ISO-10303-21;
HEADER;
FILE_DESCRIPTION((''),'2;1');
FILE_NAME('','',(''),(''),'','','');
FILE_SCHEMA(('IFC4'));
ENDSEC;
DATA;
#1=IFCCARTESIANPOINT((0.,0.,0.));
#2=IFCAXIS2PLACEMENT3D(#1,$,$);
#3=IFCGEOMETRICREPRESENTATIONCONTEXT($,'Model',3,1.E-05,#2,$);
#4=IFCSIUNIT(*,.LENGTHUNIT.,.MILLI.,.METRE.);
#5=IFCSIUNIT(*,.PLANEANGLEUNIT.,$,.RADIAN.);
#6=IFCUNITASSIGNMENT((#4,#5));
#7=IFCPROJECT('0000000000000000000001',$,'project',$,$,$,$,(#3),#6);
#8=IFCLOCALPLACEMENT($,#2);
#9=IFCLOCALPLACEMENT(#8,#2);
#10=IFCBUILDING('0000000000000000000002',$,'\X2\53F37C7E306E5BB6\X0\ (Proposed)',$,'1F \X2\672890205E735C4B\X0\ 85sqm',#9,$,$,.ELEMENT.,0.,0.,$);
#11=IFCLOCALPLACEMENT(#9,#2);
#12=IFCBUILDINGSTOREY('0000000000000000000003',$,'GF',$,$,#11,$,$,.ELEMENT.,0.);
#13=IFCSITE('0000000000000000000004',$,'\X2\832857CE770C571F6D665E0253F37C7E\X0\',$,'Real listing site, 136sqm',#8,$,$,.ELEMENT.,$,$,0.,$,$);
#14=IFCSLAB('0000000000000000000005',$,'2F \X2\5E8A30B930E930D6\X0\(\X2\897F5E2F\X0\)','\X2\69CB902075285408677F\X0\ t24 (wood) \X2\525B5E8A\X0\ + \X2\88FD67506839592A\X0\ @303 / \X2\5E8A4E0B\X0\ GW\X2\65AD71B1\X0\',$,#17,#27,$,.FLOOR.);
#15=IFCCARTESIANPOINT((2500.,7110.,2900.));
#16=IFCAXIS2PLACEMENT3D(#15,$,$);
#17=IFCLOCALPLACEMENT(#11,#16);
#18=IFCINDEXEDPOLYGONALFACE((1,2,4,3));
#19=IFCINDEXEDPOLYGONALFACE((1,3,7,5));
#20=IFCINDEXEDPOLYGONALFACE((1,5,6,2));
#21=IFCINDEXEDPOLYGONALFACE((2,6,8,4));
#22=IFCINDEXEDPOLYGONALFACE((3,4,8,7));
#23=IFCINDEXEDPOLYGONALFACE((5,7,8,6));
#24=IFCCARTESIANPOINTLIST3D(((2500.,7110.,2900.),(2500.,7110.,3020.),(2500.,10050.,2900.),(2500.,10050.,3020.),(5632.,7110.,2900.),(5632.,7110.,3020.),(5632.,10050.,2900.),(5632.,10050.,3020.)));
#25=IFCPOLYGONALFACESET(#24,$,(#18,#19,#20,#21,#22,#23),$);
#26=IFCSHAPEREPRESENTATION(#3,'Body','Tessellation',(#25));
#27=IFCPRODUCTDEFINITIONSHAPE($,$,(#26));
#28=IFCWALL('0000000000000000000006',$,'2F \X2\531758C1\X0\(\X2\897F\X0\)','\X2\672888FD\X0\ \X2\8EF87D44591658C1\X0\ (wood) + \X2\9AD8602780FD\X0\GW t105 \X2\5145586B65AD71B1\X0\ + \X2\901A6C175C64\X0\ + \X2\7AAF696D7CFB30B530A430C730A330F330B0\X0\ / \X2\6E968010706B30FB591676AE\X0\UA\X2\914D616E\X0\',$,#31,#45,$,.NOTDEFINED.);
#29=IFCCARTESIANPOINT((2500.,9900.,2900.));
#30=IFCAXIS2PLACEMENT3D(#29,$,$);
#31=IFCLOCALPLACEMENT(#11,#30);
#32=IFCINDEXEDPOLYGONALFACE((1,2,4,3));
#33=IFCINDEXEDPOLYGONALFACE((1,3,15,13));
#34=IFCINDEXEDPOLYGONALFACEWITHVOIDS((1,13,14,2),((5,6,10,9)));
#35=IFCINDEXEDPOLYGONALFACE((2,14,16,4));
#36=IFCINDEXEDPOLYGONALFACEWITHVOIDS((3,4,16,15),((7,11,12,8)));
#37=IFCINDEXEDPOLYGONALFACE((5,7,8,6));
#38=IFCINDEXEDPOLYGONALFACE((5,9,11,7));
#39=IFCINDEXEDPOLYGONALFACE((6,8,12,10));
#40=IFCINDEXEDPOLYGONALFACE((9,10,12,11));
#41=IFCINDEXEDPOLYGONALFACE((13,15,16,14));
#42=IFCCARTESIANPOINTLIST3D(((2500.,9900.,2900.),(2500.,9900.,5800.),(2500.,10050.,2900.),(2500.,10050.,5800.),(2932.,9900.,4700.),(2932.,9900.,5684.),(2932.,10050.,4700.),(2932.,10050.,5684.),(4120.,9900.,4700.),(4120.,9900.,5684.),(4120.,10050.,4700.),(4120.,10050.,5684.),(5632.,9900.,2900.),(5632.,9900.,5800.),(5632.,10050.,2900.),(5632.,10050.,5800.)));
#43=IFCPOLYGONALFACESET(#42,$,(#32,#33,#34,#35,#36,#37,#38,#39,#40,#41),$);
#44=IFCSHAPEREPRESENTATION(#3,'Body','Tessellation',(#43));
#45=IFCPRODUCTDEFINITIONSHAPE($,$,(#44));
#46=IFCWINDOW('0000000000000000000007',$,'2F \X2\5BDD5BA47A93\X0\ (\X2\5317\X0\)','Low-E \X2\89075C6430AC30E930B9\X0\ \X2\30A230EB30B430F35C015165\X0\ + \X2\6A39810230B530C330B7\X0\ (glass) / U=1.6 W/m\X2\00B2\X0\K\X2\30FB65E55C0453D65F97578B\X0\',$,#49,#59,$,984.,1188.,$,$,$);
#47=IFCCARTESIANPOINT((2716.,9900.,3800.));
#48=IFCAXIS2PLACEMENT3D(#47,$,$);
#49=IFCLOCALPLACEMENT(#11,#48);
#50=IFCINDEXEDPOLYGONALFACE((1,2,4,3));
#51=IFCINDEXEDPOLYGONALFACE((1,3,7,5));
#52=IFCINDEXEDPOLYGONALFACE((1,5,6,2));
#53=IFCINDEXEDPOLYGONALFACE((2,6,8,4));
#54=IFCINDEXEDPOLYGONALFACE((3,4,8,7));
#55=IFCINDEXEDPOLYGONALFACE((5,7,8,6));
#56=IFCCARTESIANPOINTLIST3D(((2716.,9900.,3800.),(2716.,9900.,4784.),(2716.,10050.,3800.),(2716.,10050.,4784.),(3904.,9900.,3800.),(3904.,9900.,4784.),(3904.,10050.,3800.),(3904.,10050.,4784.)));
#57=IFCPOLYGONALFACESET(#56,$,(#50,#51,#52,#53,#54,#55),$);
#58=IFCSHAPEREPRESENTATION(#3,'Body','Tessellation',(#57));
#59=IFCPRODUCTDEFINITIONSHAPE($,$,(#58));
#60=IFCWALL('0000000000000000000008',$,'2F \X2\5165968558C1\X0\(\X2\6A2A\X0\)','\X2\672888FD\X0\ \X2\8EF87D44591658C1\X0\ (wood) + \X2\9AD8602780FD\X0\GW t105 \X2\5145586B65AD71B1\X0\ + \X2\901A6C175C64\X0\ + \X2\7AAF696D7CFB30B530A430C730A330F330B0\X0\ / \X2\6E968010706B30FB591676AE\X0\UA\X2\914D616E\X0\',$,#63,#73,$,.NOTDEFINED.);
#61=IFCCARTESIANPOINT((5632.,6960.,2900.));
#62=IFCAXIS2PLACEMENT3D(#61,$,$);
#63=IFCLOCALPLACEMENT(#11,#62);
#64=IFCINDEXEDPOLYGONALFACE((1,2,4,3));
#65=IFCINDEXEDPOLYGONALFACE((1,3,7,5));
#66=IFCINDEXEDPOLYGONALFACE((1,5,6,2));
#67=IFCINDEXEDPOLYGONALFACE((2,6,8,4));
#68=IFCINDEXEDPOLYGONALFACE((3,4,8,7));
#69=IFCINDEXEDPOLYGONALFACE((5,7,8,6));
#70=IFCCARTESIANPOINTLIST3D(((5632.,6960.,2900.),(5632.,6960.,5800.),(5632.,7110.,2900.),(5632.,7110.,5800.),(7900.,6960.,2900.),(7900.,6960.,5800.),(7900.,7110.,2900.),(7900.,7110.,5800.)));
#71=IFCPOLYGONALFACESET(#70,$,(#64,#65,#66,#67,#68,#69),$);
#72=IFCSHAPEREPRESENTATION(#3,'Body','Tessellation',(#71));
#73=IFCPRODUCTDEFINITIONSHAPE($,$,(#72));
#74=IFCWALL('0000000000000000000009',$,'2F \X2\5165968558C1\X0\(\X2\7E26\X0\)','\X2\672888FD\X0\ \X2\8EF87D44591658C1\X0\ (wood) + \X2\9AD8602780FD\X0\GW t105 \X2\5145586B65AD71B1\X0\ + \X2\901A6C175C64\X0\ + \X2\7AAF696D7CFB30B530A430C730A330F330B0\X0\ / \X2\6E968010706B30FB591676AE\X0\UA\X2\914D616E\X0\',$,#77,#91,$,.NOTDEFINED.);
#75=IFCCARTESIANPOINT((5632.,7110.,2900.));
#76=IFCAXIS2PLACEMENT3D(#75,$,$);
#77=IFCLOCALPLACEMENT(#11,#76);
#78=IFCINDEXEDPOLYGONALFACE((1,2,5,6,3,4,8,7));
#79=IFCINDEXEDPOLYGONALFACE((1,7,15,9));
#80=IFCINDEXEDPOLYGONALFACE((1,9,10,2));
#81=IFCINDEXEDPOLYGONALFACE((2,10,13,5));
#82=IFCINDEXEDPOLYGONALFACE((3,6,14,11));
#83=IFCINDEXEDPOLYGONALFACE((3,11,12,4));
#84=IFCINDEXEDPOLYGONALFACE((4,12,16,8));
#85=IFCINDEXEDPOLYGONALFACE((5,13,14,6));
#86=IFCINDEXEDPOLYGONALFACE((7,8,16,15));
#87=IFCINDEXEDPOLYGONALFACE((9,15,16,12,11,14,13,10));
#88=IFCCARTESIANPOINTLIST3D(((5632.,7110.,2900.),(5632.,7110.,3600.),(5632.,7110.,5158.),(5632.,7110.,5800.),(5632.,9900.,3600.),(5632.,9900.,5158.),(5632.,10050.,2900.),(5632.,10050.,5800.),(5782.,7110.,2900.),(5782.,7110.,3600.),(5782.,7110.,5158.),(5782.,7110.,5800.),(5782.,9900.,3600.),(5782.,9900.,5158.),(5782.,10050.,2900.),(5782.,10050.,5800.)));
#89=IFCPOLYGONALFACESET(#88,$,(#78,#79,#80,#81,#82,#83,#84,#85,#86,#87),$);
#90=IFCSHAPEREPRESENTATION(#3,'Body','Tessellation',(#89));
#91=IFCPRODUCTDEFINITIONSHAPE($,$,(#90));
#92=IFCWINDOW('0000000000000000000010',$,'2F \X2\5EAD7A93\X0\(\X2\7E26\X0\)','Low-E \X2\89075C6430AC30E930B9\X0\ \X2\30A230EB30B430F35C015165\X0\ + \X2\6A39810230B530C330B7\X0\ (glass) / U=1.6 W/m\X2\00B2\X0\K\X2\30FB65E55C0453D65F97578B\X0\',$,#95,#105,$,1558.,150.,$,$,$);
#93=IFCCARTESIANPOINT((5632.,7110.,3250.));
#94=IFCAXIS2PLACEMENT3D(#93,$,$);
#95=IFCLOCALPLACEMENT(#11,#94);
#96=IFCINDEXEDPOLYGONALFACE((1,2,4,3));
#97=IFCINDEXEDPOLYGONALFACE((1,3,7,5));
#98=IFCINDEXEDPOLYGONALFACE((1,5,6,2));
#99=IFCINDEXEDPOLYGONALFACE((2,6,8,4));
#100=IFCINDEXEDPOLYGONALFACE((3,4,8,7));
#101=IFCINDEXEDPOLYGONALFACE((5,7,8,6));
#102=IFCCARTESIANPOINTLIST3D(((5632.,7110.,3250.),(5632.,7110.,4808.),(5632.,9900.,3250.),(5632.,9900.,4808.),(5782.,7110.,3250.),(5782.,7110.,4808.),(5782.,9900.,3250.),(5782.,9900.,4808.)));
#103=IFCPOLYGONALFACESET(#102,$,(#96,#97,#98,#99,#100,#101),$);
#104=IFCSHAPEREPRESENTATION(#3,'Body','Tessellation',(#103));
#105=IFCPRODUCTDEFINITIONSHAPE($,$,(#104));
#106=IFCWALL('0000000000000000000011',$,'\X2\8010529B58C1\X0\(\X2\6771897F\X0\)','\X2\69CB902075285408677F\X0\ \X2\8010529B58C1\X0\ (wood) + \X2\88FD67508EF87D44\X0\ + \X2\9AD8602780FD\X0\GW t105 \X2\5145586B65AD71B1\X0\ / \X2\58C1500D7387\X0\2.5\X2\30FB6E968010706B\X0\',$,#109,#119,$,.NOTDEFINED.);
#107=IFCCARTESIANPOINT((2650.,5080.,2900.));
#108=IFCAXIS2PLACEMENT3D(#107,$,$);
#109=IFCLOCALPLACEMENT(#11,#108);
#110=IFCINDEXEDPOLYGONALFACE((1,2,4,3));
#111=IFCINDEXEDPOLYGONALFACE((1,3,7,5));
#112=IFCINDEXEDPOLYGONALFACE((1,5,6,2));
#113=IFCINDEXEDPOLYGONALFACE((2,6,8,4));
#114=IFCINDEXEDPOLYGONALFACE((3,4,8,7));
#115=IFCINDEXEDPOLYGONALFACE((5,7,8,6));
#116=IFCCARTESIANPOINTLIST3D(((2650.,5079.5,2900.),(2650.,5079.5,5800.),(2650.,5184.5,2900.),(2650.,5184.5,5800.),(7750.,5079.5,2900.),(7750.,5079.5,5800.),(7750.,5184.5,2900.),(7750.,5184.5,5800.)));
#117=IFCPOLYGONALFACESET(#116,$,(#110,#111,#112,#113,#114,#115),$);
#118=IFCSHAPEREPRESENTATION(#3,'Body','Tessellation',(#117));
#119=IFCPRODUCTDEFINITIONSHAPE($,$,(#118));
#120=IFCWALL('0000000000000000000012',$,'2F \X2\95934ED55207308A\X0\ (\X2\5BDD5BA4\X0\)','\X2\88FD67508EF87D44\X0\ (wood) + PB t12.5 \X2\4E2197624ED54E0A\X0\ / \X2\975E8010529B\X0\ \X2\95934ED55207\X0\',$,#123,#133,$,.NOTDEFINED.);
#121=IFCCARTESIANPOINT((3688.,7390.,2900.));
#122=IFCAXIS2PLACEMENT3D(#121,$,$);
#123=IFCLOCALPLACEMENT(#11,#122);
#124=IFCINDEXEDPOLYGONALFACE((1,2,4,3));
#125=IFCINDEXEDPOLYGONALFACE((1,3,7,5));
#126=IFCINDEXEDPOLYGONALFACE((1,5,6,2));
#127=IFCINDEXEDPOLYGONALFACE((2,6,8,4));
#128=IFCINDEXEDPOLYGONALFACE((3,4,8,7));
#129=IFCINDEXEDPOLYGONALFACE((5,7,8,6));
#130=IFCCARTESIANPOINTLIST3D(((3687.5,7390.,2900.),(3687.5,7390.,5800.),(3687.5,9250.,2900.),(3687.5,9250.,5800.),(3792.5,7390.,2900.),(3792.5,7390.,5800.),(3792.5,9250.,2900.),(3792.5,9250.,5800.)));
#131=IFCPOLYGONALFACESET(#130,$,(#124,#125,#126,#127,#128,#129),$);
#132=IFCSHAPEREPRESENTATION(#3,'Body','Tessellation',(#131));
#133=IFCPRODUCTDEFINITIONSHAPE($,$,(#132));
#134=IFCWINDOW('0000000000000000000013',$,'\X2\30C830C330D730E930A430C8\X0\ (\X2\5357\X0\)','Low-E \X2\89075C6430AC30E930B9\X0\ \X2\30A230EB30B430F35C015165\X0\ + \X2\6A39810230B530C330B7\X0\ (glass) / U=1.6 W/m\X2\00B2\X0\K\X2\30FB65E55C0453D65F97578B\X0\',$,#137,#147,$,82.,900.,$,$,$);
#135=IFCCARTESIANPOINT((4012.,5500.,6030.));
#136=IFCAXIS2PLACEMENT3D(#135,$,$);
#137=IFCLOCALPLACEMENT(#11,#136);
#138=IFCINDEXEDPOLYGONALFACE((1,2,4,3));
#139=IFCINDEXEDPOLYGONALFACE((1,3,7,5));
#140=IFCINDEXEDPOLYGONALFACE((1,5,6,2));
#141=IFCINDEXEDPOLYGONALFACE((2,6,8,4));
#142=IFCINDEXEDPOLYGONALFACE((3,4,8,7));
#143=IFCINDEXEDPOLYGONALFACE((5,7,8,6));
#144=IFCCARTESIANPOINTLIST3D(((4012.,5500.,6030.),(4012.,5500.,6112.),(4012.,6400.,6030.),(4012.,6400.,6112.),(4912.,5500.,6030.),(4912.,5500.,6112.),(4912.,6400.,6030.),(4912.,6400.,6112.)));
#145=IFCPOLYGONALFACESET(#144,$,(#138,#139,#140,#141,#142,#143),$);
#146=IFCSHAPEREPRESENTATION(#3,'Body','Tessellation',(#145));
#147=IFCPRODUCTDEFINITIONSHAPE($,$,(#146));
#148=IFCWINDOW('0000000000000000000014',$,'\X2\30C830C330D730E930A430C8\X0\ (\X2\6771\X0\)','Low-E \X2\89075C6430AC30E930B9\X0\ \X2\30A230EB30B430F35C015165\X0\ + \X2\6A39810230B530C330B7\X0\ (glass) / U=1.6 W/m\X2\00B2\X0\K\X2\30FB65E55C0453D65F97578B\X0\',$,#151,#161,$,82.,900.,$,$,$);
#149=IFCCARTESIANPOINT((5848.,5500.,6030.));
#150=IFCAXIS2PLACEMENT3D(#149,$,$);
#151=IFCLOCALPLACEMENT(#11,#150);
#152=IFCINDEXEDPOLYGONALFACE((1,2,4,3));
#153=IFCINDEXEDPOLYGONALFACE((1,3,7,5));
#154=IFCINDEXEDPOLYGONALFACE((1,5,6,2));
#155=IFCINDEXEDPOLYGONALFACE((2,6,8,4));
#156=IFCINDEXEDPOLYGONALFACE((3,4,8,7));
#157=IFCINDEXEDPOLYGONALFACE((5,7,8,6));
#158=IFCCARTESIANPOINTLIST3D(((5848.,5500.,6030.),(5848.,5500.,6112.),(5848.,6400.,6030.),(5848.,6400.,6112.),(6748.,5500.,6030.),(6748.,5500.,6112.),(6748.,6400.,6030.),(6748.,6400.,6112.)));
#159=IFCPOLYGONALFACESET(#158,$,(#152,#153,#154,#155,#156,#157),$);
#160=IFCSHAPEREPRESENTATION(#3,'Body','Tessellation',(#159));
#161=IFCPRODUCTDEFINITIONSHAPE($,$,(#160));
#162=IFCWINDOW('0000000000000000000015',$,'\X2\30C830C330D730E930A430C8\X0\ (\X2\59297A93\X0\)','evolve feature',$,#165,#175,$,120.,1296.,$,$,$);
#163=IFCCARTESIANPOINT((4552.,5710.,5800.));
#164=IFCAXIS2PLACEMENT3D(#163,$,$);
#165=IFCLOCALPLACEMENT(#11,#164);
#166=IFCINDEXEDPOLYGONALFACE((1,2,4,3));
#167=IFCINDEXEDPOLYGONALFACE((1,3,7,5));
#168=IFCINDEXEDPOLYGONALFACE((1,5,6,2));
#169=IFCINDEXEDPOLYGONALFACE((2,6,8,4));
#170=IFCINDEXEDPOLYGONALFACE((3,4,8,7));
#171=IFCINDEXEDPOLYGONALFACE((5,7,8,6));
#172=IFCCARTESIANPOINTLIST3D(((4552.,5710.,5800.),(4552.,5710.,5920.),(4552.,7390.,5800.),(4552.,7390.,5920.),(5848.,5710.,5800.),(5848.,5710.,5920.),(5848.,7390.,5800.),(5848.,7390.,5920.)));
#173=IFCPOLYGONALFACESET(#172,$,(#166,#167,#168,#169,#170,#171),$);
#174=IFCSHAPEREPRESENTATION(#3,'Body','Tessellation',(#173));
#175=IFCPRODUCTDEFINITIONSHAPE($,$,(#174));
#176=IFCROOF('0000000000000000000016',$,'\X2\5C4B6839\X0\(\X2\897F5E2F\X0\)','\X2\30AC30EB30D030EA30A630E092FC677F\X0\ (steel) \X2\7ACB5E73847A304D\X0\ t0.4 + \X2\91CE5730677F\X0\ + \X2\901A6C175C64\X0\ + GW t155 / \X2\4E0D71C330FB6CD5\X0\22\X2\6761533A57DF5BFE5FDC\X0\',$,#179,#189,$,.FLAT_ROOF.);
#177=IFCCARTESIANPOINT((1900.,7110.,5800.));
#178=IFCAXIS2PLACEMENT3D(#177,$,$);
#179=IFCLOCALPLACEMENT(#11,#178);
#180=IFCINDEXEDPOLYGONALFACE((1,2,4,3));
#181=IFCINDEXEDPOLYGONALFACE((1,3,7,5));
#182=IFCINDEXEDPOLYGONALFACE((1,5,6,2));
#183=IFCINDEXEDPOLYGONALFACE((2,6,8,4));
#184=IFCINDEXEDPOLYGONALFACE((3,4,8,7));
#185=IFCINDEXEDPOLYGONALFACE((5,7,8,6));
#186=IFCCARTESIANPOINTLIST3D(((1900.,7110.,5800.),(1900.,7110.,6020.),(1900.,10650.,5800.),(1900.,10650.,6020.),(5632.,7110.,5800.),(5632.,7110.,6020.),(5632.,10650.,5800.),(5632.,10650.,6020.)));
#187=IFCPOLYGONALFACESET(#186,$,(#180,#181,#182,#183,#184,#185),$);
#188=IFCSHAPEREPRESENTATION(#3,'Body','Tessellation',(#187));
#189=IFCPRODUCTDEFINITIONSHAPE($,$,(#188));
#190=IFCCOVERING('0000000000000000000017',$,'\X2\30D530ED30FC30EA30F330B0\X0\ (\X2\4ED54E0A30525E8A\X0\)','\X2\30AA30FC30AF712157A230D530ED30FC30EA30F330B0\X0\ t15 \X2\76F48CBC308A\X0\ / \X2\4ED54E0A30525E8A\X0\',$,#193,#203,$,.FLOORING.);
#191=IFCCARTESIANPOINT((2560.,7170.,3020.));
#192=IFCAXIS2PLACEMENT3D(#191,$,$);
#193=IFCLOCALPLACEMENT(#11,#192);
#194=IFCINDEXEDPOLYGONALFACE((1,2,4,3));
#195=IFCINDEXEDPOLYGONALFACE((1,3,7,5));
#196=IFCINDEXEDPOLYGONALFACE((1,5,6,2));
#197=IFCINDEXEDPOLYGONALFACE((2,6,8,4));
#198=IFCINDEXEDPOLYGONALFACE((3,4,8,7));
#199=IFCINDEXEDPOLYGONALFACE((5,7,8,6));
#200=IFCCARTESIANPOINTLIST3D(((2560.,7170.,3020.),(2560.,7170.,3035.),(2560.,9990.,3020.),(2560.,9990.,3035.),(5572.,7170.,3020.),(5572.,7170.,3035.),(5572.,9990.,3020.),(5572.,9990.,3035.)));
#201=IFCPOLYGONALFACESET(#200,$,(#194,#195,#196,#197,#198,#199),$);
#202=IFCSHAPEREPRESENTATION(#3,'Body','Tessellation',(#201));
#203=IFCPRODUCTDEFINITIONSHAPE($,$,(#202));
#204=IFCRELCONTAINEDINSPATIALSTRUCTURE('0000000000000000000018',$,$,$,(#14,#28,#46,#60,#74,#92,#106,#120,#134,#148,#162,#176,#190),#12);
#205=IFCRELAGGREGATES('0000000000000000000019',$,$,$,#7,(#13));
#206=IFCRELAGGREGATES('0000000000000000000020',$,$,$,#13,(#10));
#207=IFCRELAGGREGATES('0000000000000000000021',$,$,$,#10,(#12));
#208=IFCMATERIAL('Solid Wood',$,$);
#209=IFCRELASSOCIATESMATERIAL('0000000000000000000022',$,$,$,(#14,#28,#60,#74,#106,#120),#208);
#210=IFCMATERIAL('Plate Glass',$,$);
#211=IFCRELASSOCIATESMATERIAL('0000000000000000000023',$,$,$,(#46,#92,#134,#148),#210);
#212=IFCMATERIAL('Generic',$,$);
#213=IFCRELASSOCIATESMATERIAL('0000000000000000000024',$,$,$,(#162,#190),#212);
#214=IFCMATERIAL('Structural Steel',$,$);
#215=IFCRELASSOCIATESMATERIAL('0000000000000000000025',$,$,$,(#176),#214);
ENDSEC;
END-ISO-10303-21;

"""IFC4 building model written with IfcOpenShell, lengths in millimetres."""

from ifc_helpers import new_model, si_unit, frame, frame_2d, origin, place, context, project, spatial, rectangle, extrude, material, element, fill, save


model = new_model("IFC4")

# Units and contexts
model_context = context("Model", 3, precision=1e-05, world=origin())
ifc_project = project(units=[si_unit("LENGTHUNIT", "METRE", prefix="MILLI"), si_unit("PLANEANGLEUNIT", "RADIAN")], contexts=[model_context])

# Site, building, storey
site_placement = place(None, origin())
site = spatial("IfcSite", under=ifc_project, at=site_placement, Name="茨城県土浦市右籾", ObjectType="Real listing site, 136sqm", CompositionType="ELEMENT", RefElevation=0.0)
building_placement = place(site_placement, origin())
building = spatial("IfcBuilding", under=site, at=building_placement, Name="右籾の家 (Proposed)", ObjectType="1F 木造平屋 85sqm", CompositionType="ELEMENT", ElevationOfRefHeight=0.0, ElevationOfTerrain=0.0)
storey_placement = place(building_placement, origin())
storey = spatial("IfcBuildingStorey", under=building, at=storey_placement, Name="GF", CompositionType="ELEMENT", Elevation=0.0)

# Slab
ifc_material_1 = material(Name="Solid Wood")
slab_placement = place(storey_placement, frame((2500.0, 7110.0, 2900.0)))
element("IfcSlab", 1, at=slab_placement, inside=storey, material=ifc_material_1, Name="2F 床スラブ(西帯)", Description="構造用合板 t24 (wood) 剛床 + 製材根太 @303 / 床下 GW断熱", PredefinedType="FLOOR", context=model_context, shape_type="SweptSolid", body=[
    extrude(rectangle(XDim=3132.0, YDim=2940.0, at=frame_2d((1566.0, 1470.0))), frame((2500.0, 7110.0, 2900.0)), (0.0, 0.0, 1.0), 120.0),
])

# Wall, opening, window
wall_1_placement = place(storey_placement, frame((2500.0, 9900.0, 2900.0)))
wall_1 = element("IfcWall", 2, at=wall_1_placement, inside=storey, material=ifc_material_1, Name="2F 北壁(西)", Description="木製 軸組外壁 (wood) + 高性能GW t105 充填断熱 + 通気層 + 窯業系サイディング / 準耐火・外皮UA配慮", PredefinedType="NOTDEFINED", context=model_context, shape_type="SweptSolid", body=[
    extrude(rectangle(XDim=3132.0, YDim=150.0, at=frame_2d((1566.0, 75.0))), frame((2500.0, 9900.0, 2900.0)), (0.0, 0.0, 1.0), 2900.0),
])
opening_1_placement = place(storey_placement, frame((2716.0, 9900.0, 3800.0)))
opening_1 = element("IfcOpeningElement", 3, at=opening_1_placement, cuts=wall_1, PredefinedType="NOTDEFINED", context=model_context, shape_type="SweptSolid", body=[
    extrude(rectangle(XDim=1188.0, YDim=150.0, at=frame_2d((594.0, 75.0))), frame((2716.0, 9900.0, 3800.0)), (0.0, 0.0, 1.0), 984.0),
])
ifc_material_2 = material(Name="Plate Glass")
window_1_placement = place(storey_placement, frame((2716.0, 9900.0, 3800.0)))
window_1 = element("IfcWindow", 4, at=window_1_placement, inside=storey, material=ifc_material_2, Name="2F 寝室窓 (北)", Description="Low-E 複層ガラス アルゴン封入 + 樹脂サッシ (glass) / U=1.6 W/m²K・日射取得型", OverallHeight=984.0, OverallWidth=1188.0, context=model_context, shape_type="SweptSolid", body=[
    extrude(rectangle(XDim=1188.0, YDim=150.0, at=frame_2d((594.0, 75.0))), frame((2716.0, 9900.0, 3800.0)), (0.0, 0.0, 1.0), 984.0),
])
fill(opening_1, window_1)

# Wall
wall_2_placement = place(storey_placement, frame((5632.0, 6960.0, 2900.0)))
element("IfcWall", 5, at=wall_2_placement, inside=storey, material=ifc_material_1, Name="2F 入隅壁(横)", Description="木製 軸組外壁 (wood) + 高性能GW t105 充填断熱 + 通気層 + 窯業系サイディング / 準耐火・外皮UA配慮", PredefinedType="NOTDEFINED", context=model_context, shape_type="SweptSolid", body=[
    extrude(rectangle(XDim=2268.0, YDim=150.0, at=frame_2d((1134.0, 75.0))), frame((5632.0, 6960.0, 2900.0)), (0.0, 0.0, 1.0), 2900.0),
])

# Wall, opening, window
wall_3_placement = place(storey_placement, frame((5632.0, 7110.0, 2900.0)))
wall_3 = element("IfcWall", 6, at=wall_3_placement, inside=storey, material=ifc_material_1, Name="2F 入隅壁(縦)", Description="木製 軸組外壁 (wood) + 高性能GW t105 充填断熱 + 通気層 + 窯業系サイディング / 準耐火・外皮UA配慮", PredefinedType="NOTDEFINED", context=model_context, shape_type="SweptSolid", body=[
    extrude(rectangle(XDim=150.0, YDim=2940.0, at=frame_2d((75.0, 1470.0))), frame((5632.0, 7110.0, 2900.0)), (0.0, 0.0, 1.0), 2900.0),
])
opening_2_placement = place(storey_placement, frame((5632.0, 7110.0, 3250.0)))
opening_2 = element("IfcOpeningElement", 7, at=opening_2_placement, cuts=wall_3, PredefinedType="NOTDEFINED", context=model_context, shape_type="SweptSolid", body=[
    extrude(rectangle(XDim=150.0, YDim=2790.0, at=frame_2d((75.0, 1395.0))), frame((5632.0, 7110.0, 3250.0)), (0.0, 0.0, 1.0), 1558.0),
])
window_2_placement = place(storey_placement, frame((5632.0, 7110.0, 3250.0)))
window_2 = element("IfcWindow", 8, at=window_2_placement, inside=storey, material=ifc_material_2, Name="2F 庭窓(縦)", Description="Low-E 複層ガラス アルゴン封入 + 樹脂サッシ (glass) / U=1.6 W/m²K・日射取得型", OverallHeight=1558.0, OverallWidth=150.0, context=model_context, shape_type="SweptSolid", body=[
    extrude(rectangle(XDim=150.0, YDim=2790.0, at=frame_2d((75.0, 1395.0))), frame((5632.0, 7110.0, 3250.0)), (0.0, 0.0, 1.0), 1558.0),
])
fill(opening_2, window_2)

# Walls
wall_4_placement = place(storey_placement, frame((2650.0, 5080.0, 2900.0)))
element("IfcWall", 9, at=wall_4_placement, inside=storey, material=ifc_material_1, Name="耐力壁(東西)", Description="構造用合板 耐力壁 (wood) + 製材軸組 + 高性能GW t105 充填断熱 / 壁倍率2.5・準耐火", PredefinedType="NOTDEFINED", context=model_context, shape_type="SweptSolid", body=[
    extrude(rectangle(XDim=5100.0, YDim=105.0, at=frame_2d((2550.0, 52.0))), frame((2650.0, 5080.0, 2900.0)), (0.0, 0.0, 1.0), 2900.0),
])
wall_5_placement = place(storey_placement, frame((3688.0, 7390.0, 2900.0)))
element("IfcWall", 10, at=wall_5_placement, inside=storey, material=ifc_material_1, Name="2F 間仕切り (寝室)", Description="製材軸組 (wood) + PB t12.5 両面仕上 / 非耐力 間仕切", PredefinedType="NOTDEFINED", context=model_context, shape_type="SweptSolid", body=[
    extrude(rectangle(XDim=105.0, YDim=1860.0, at=frame_2d((52.0, 930.0))), frame((3688.0, 7390.0, 2900.0)), (0.0, 0.0, 1.0), 2900.0),
])

# Windows
window_3_placement = place(storey_placement, frame((4012.0, 5500.0, 6030.0)))
element("IfcWindow", 11, at=window_3_placement, inside=storey, material=ifc_material_2, Name="トップライト (南)", Description="Low-E 複層ガラス アルゴン封入 + 樹脂サッシ (glass) / U=1.6 W/m²K・日射取得型", OverallHeight=82.0, OverallWidth=900.0, context=model_context, shape_type="SweptSolid", body=[
    extrude(rectangle(XDim=900.0, YDim=900.0, at=frame_2d((450.0, 450.0))), frame((4012.0, 5500.0, 6030.0)), (0.0, 0.0, 1.0), 82.0),
])
window_4_placement = place(storey_placement, frame((5848.0, 5500.0, 6030.0)))
element("IfcWindow", 12, at=window_4_placement, inside=storey, material=ifc_material_2, Name="トップライト (東)", Description="Low-E 複層ガラス アルゴン封入 + 樹脂サッシ (glass) / U=1.6 W/m²K・日射取得型", OverallHeight=82.0, OverallWidth=900.0, context=model_context, shape_type="SweptSolid", body=[
    extrude(rectangle(XDim=900.0, YDim=900.0, at=frame_2d((450.0, 450.0))), frame((5848.0, 5500.0, 6030.0)), (0.0, 0.0, 1.0), 82.0),
])
ifc_material_3 = material(Name="Generic")
window_5_placement = place(storey_placement, frame((4552.0, 5710.0, 5800.0)))
element("IfcWindow", 13, at=window_5_placement, inside=storey, material=ifc_material_3, Name="トップライト (天窓)", Description="evolve feature", OverallHeight=120.0, OverallWidth=1296.0, context=model_context, shape_type="SweptSolid", body=[
    extrude(rectangle(XDim=1296.0, YDim=1680.0, at=frame_2d((648.0, 840.0))), frame((4552.0, 5710.0, 5800.0)), (0.0, 0.0, 1.0), 120.0),
])

# Roof
ifc_material_4 = material(Name="Structural Steel")
for number, where, name in (
    (14, (1900.0, 7110.0, 5800.0), "屋根(西帯)"),
):
    element("IfcRoof", number, at=place(storey_placement, frame(where)), inside=storey, material=ifc_material_4, Name=name, Description="ガルバリウム鋼板 (steel) 立平葺き t0.4 + 野地板 + 通気層 + GW t155 / 不燃・法22条区域対応", PredefinedType="FLAT_ROOF", context=model_context, shape_type="SweptSolid", body=[
        extrude(rectangle(XDim=3732.0, YDim=3540.0, at=frame_2d((1866.0, 1770.0))), frame((1900.0, 7110.0, 5800.0)), (0.0, 0.0, 1.0), 220.0),
    ])

# Covering
covering_placement = place(storey_placement, frame((2560.0, 7170.0, 3020.0)))
element("IfcCovering", 15, at=covering_placement, inside=storey, material=ifc_material_3, Name="フローリング (仕上げ床)", Description="オーク無垢フローリング t15 直貼り / 仕上げ床", PredefinedType="FLOORING", context=model_context, shape_type="SweptSolid", body=[
    extrude(rectangle(XDim=3012.0, YDim=2820.0, at=frame_2d((1506.0, 1410.0))), frame((2560.0, 7170.0, 3020.0)), (0.0, 0.0, 1.0), 15.0),
])

save(model, "model.ifc")
